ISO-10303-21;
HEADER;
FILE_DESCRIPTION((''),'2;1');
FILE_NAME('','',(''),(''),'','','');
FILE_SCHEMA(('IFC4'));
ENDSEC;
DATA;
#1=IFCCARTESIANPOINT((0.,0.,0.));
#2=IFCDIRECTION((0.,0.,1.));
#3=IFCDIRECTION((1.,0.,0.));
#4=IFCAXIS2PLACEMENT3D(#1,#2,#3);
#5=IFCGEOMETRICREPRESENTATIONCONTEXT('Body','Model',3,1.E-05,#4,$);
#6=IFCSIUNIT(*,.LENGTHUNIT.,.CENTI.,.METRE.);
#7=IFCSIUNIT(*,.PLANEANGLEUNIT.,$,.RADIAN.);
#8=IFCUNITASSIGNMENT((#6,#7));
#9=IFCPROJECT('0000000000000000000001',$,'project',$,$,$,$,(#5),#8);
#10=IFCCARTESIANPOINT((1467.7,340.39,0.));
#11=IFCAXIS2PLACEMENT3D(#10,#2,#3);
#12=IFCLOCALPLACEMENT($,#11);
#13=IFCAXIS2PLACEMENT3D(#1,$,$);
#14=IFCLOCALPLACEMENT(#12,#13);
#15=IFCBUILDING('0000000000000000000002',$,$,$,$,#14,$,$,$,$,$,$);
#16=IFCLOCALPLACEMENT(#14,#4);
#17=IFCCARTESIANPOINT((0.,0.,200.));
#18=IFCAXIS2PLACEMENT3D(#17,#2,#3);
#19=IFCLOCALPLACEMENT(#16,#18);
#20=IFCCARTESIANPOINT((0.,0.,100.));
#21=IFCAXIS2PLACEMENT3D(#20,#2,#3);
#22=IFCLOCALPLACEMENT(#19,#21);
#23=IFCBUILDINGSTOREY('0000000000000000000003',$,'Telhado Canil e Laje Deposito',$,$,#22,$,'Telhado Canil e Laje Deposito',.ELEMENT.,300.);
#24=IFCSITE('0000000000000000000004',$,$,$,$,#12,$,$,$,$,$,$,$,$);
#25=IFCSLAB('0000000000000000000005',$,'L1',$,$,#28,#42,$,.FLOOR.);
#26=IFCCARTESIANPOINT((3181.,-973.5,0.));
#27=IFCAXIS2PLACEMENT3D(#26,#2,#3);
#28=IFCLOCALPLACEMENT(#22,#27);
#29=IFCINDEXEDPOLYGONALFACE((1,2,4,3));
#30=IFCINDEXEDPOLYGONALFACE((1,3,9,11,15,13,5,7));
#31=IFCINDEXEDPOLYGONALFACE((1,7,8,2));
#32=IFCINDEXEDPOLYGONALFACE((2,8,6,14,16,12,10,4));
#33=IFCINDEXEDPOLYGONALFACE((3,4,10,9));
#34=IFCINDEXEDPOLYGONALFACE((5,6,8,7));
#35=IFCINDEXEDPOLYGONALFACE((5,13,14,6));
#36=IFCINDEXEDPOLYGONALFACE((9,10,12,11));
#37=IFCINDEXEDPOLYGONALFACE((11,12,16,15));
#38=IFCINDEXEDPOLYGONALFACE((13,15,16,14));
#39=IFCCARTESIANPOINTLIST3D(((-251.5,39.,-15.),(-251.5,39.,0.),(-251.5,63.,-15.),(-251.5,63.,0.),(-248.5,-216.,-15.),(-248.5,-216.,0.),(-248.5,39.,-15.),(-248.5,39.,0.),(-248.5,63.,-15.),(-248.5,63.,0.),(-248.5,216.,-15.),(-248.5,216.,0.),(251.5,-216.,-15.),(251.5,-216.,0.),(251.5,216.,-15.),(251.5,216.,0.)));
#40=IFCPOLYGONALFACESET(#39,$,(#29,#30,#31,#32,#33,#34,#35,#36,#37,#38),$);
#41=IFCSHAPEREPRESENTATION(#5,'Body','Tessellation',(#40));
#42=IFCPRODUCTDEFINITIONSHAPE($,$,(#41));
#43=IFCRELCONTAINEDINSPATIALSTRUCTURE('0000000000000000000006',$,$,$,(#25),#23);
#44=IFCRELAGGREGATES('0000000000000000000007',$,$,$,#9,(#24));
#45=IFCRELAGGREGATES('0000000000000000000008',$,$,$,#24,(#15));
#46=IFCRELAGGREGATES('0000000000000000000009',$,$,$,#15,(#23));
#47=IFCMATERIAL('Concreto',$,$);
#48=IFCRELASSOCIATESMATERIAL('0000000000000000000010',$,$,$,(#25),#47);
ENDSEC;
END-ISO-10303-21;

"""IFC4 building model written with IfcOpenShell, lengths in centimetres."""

from ifc_helpers import new_model, si_unit, frame, origin, origin_with_axes, place, context, project, spatial, polyline, outline, extrude, material, element, save


model = new_model("IFC4")

# Units and contexts
model_context = context("Model", 3, precision=1e-05, world=origin_with_axes(), identifier="Body")
ifc_project = project(units=[si_unit("LENGTHUNIT", "METRE", prefix="CENTI"), si_unit("PLANEANGLEUNIT", "RADIAN")], contexts=[model_context])

# Site, building, storey
site_placement = place(None, frame((1467.7, 340.39, 0.0), z_axis=(0.0, 0.0, 1.0), x_axis=(1.0, 0.0, 0.0)))
site = spatial("IfcSite", under=ifc_project, at=site_placement)
building_placement = place(site_placement, origin())
building = spatial("IfcBuilding", under=site, at=building_placement)
placement_1 = place(building_placement, origin_with_axes())
placement_2 = place(placement_1, frame((0.0, 0.0, 200.0), z_axis=(0.0, 0.0, 1.0), x_axis=(1.0, 0.0, 0.0)))
storey_placement = place(placement_2, frame((0.0, 0.0, 100.0), z_axis=(0.0, 0.0, 1.0), x_axis=(1.0, 0.0, 0.0)))
storey = spatial("IfcBuildingStorey", under=building, at=storey_placement, Name="Telhado Canil e Laje Deposito", LongName="Telhado Canil e Laje Deposito", CompositionType="ELEMENT", Elevation=300.0)

# Shared definitions
ifc_material = material(Name="Concreto")

# Slab
slab_placement = place(storey_placement, frame((3181.0, -973.5, 0.0), z_axis=(0.0, 0.0, 1.0), x_axis=(1.0, 0.0, 0.0)))
element("IfcSlab", 1, at=slab_placement, inside=storey, material=ifc_material, Name="L1", PredefinedType="FLOOR", context=model_context, shape_type="SolidModel", body=[
    extrude(outline(polyline([(251.5, 216.0), (-248.5, 216.0), (-248.5, 63.0), (-251.5, 63.0), (-251.5, 39.0), (-248.5, 39.0), (-248.5, -216.0), (251.5, -216.0), (251.5, 216.0), (251.5, 216.0)])), frame((0.0, 0.0, -15.0), z_axis=(0.0, 0.0, 1.0), x_axis=(1.0, 0.0, 0.0)), (0.0, 0.0, 1.0), 15.0),
])

save(model, "model.ifc")
